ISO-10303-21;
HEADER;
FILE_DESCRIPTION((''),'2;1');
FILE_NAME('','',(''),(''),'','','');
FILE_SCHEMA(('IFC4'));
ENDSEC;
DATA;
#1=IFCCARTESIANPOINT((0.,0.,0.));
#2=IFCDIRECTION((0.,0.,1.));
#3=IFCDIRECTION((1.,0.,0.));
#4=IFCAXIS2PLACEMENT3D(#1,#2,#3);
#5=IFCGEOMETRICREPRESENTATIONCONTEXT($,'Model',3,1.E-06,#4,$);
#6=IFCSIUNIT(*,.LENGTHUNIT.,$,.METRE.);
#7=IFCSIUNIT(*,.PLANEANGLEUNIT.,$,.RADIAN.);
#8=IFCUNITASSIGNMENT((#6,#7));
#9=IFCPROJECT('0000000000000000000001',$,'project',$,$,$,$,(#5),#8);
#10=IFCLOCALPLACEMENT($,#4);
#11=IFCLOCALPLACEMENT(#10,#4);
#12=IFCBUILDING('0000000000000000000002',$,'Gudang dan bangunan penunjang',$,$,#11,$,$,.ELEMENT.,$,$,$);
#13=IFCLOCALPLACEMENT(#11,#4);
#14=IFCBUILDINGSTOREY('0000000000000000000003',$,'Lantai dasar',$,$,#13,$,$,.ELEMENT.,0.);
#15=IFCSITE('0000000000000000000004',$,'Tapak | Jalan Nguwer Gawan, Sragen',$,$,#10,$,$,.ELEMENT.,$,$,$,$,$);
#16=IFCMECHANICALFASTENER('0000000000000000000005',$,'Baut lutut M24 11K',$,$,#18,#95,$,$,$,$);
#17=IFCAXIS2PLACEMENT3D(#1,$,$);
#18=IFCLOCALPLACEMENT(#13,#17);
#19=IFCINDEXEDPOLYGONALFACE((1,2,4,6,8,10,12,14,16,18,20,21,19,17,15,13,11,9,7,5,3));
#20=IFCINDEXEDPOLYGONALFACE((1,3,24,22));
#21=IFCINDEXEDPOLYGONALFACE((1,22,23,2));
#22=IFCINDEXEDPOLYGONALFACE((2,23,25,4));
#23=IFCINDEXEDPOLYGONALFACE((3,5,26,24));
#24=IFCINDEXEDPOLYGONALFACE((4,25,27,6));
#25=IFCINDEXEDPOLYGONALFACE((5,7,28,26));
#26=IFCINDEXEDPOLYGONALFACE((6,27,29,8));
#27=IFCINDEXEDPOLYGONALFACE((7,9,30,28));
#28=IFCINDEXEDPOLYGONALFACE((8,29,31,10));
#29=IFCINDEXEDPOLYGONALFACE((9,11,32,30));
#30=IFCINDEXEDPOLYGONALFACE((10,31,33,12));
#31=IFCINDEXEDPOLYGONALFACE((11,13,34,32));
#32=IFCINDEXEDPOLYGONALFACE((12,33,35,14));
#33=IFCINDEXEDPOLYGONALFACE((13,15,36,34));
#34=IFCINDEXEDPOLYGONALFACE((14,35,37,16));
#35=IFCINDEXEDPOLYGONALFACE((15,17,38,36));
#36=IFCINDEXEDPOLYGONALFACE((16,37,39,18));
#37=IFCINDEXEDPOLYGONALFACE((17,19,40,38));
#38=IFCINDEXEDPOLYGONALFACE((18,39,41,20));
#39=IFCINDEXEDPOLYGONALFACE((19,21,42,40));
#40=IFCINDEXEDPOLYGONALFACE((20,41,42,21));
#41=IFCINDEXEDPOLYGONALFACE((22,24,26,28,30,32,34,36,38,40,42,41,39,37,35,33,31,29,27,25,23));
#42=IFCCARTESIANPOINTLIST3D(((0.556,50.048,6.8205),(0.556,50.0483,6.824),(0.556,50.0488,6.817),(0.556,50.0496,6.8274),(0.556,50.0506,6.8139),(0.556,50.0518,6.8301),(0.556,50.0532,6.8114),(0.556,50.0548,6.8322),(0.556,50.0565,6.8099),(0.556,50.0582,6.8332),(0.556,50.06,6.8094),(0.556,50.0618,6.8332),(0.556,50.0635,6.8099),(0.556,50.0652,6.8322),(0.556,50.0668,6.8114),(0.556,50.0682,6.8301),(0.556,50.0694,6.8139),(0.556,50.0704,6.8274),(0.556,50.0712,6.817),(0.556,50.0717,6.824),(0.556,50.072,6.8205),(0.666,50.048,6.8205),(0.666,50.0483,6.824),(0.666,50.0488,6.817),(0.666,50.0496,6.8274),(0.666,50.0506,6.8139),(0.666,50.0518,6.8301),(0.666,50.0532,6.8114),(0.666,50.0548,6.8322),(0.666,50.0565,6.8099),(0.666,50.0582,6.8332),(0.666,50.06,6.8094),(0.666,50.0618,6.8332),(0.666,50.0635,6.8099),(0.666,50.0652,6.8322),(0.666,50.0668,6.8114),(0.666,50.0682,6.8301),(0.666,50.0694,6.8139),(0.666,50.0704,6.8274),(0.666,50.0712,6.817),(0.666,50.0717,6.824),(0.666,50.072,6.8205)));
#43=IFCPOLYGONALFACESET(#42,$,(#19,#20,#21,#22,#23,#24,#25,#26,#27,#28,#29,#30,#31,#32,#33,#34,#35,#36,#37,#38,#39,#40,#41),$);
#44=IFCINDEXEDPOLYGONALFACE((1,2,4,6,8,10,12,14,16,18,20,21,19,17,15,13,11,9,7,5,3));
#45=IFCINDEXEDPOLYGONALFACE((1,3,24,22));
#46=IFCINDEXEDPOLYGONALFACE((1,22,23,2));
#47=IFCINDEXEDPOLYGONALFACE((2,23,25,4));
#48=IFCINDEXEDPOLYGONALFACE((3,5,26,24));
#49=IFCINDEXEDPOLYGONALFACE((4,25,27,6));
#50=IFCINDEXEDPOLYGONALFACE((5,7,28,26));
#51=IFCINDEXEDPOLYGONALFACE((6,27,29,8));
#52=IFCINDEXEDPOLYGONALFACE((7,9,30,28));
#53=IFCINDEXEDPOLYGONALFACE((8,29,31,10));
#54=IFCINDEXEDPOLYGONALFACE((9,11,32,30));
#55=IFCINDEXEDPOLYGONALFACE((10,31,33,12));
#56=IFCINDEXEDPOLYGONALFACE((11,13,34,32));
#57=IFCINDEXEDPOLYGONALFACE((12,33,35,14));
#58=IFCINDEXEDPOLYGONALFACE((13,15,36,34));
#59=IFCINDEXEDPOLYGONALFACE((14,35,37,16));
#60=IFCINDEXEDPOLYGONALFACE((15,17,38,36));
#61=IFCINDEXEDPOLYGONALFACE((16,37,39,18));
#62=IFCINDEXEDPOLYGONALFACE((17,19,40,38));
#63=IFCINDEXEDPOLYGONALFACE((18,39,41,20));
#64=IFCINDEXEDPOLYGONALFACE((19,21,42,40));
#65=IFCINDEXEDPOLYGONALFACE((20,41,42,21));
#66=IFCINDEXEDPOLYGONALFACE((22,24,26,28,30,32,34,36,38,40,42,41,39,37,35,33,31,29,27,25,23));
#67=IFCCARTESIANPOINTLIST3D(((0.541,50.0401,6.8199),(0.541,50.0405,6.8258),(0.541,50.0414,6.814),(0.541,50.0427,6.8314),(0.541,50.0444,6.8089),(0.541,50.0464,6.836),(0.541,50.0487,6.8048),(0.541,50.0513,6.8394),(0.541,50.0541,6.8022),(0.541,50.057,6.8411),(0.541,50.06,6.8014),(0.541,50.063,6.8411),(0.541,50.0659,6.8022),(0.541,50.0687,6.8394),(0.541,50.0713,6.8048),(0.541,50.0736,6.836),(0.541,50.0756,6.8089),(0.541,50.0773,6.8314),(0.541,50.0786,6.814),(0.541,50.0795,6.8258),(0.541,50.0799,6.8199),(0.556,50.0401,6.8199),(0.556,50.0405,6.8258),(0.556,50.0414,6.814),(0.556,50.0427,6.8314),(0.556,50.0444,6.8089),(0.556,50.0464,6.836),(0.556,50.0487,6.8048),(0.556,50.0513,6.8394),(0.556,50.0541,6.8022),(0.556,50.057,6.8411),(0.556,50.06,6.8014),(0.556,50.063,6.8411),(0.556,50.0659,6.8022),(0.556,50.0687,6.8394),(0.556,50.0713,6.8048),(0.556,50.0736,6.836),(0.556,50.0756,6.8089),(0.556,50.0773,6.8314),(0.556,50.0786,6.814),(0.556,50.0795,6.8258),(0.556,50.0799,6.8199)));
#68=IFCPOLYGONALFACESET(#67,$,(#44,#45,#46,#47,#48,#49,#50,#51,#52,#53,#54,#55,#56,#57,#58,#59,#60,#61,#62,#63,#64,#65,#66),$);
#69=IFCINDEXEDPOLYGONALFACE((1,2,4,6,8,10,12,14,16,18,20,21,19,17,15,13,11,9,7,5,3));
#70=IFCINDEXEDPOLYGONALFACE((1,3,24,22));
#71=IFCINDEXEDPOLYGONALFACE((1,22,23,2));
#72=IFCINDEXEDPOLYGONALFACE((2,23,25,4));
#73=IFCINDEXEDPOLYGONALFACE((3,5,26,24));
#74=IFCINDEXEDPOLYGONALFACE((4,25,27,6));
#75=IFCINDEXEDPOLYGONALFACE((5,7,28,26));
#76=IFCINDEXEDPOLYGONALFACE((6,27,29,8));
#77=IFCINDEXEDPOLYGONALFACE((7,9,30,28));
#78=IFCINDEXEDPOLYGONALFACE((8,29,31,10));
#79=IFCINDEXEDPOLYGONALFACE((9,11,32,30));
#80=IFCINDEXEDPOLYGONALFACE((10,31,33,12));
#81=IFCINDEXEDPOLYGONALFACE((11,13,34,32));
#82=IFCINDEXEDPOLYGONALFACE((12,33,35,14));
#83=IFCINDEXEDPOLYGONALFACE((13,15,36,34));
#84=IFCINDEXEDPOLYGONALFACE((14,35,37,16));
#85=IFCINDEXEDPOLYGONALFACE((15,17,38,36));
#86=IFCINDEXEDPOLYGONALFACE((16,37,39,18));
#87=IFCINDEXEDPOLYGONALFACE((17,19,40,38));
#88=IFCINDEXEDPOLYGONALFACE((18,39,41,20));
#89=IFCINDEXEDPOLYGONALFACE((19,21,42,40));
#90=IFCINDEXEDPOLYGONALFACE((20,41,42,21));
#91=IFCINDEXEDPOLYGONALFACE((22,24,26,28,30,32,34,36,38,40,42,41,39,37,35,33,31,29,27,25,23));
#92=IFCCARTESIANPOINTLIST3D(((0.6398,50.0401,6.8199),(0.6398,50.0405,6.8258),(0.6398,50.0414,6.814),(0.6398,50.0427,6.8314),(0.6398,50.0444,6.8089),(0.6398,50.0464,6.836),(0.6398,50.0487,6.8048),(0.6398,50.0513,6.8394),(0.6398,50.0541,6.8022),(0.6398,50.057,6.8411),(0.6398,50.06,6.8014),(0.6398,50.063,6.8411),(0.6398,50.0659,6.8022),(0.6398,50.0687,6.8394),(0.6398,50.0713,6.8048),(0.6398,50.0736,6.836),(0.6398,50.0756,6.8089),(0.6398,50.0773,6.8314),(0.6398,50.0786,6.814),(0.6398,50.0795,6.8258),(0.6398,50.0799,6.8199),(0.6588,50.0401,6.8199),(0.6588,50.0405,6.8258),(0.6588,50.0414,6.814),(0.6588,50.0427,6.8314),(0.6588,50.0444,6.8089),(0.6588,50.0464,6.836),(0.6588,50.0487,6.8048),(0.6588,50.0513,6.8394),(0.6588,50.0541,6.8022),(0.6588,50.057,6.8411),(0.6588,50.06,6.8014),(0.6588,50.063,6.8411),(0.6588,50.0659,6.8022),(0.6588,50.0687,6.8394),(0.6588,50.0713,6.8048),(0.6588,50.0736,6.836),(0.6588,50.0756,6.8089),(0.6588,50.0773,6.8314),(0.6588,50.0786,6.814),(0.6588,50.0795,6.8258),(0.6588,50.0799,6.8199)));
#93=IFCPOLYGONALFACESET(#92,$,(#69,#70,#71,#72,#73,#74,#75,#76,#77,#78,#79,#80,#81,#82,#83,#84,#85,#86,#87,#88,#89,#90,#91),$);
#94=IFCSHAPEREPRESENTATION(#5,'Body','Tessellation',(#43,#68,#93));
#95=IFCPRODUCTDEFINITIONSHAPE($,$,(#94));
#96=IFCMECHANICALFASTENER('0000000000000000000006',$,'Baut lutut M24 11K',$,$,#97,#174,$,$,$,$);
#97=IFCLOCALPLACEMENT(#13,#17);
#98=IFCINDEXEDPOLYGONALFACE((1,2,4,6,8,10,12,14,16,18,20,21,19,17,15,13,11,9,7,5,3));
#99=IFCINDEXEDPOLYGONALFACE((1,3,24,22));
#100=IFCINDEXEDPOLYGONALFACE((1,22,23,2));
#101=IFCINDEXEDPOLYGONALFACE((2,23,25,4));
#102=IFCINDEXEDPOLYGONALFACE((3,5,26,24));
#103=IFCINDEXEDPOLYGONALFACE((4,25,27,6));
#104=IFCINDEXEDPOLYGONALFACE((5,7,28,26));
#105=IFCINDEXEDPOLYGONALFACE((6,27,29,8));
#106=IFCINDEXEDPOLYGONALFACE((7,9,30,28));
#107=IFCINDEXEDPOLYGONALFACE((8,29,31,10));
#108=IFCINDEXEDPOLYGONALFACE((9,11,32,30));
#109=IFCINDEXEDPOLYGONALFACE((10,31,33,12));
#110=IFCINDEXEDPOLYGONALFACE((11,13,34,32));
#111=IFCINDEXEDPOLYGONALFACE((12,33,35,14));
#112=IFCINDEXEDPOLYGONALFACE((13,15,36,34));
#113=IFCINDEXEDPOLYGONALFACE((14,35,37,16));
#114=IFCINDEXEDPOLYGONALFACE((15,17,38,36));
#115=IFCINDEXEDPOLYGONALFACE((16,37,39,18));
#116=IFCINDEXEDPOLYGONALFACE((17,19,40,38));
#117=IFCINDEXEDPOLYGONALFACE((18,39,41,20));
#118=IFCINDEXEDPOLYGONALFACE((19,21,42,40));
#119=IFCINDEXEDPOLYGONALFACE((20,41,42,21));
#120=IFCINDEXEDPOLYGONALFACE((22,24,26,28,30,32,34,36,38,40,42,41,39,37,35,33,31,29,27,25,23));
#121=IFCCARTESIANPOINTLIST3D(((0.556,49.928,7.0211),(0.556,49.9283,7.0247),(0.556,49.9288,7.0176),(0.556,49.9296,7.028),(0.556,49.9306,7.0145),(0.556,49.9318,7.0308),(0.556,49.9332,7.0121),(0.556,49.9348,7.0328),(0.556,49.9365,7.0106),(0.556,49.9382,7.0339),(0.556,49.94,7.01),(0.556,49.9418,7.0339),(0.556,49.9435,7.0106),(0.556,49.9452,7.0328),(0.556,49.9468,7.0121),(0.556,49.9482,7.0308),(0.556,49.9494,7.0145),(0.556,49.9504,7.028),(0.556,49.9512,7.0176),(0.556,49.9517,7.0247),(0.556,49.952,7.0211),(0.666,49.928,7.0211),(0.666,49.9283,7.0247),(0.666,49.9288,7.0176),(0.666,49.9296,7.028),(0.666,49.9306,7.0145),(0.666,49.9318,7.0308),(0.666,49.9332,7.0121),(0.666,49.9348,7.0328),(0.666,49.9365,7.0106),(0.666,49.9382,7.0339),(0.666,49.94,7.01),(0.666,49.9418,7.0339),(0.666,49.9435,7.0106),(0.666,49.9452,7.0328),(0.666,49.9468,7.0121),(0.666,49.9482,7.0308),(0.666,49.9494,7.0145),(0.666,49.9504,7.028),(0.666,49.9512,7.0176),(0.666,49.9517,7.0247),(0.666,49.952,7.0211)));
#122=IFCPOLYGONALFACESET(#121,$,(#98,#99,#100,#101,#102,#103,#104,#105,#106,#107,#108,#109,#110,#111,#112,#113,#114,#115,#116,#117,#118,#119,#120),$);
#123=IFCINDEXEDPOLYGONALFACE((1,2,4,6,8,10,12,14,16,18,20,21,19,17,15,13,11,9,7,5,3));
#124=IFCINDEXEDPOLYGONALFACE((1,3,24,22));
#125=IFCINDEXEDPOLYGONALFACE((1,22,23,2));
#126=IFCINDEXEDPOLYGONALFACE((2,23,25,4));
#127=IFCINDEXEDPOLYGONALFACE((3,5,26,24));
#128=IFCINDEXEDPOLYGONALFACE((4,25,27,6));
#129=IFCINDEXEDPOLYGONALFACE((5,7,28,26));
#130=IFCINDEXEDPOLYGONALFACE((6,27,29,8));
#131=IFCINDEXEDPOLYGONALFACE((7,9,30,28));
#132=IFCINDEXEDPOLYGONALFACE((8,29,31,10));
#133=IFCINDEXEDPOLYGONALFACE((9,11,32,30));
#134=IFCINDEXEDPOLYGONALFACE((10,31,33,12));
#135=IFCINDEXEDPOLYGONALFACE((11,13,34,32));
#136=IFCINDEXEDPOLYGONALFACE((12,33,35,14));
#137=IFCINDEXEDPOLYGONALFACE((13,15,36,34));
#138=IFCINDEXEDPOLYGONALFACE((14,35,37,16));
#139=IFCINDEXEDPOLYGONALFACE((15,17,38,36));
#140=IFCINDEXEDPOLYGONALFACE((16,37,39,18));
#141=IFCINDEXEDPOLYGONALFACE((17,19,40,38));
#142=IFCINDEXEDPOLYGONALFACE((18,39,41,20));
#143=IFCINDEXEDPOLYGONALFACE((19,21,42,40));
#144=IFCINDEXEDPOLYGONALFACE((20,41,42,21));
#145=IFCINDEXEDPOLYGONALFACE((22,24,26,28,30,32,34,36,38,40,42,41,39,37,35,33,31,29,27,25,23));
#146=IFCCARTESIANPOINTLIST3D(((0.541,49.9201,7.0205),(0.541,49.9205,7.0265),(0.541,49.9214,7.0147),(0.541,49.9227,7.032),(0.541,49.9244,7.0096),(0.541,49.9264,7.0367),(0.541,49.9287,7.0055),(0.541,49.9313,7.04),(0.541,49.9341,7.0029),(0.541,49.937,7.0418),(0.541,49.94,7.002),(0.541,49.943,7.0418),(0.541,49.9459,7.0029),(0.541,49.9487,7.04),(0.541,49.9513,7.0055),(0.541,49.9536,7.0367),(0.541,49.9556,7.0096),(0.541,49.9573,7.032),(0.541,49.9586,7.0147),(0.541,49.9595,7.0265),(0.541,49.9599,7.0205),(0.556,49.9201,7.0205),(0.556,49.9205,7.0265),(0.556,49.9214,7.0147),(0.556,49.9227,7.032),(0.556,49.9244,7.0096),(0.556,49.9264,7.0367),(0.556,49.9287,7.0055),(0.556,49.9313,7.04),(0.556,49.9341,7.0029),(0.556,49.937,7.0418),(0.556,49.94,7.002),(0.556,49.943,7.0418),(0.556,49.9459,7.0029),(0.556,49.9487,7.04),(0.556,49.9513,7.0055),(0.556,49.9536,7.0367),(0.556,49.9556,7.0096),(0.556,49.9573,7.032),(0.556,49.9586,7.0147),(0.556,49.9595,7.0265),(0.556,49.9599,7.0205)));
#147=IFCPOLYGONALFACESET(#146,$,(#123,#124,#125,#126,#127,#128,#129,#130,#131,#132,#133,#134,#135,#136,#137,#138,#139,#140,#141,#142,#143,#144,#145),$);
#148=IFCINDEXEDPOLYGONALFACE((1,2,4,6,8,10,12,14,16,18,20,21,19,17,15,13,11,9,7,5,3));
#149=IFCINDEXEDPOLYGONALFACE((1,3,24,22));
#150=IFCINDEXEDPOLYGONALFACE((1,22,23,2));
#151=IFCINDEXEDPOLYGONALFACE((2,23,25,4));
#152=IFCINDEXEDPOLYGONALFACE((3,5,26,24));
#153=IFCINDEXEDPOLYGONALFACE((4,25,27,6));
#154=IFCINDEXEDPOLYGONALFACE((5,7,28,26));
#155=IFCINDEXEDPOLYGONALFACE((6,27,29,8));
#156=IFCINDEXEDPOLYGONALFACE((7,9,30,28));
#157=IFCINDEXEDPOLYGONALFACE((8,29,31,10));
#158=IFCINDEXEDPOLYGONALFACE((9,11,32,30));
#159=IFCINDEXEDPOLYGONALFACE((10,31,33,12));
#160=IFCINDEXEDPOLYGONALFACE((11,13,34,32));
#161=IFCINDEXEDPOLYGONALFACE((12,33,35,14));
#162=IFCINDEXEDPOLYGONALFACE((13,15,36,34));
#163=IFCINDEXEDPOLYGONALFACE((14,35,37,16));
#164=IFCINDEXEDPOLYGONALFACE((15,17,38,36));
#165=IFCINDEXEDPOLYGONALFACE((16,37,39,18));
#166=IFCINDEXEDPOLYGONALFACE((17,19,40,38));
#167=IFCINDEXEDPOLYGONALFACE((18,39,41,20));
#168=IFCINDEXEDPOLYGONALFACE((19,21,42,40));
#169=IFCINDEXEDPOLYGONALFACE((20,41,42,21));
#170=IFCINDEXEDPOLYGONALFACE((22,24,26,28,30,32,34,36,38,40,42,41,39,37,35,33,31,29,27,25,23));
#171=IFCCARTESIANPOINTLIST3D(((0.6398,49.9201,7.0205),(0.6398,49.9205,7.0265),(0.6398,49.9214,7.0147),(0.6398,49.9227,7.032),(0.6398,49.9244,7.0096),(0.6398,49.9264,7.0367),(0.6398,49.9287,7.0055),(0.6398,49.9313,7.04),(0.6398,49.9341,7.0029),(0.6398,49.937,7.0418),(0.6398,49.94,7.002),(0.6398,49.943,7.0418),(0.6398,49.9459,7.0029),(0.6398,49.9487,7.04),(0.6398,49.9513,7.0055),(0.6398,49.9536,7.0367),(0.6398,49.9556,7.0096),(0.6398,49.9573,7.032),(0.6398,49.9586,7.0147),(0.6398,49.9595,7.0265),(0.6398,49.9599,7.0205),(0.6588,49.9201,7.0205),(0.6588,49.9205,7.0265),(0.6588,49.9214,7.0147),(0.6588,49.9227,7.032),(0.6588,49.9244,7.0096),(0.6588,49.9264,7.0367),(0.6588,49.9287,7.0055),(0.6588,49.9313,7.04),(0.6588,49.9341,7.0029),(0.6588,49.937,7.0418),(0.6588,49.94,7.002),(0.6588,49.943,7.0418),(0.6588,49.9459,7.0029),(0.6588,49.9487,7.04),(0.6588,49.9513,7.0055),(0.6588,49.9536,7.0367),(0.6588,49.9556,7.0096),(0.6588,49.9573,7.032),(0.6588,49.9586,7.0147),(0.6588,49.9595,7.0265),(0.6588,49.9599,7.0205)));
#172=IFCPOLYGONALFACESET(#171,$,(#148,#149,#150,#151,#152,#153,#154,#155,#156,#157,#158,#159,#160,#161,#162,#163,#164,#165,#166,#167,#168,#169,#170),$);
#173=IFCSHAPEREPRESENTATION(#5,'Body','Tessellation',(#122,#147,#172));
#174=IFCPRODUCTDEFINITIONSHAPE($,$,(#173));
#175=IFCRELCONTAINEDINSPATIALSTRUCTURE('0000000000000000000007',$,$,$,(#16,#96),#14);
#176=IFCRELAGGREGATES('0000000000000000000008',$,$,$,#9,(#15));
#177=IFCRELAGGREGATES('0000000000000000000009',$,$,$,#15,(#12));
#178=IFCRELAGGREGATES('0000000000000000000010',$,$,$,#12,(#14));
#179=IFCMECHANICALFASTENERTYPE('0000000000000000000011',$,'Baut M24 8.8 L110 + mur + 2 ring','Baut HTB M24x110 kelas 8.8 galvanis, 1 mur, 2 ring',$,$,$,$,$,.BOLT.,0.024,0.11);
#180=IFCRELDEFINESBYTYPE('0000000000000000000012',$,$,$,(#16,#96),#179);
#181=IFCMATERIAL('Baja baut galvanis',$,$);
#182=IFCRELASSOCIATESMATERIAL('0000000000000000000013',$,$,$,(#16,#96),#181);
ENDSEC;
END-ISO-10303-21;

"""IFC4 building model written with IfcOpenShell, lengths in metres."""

from ifc_helpers import new_model, si_unit, frame, origin_with_axes, place, context, project, spatial, circle, extrude, source, transform, mapped, material, type_object, type_shapes, element, save


model = new_model("IFC4")

# Units and contexts
model_context = context("Model", 3, precision=1e-06, world=origin_with_axes())
ifc_project = project(units=[si_unit("LENGTHUNIT", "METRE"), si_unit("PLANEANGLEUNIT", "RADIAN")], contexts=[model_context])

# Site, building, storey
site_placement = place(None, origin_with_axes())
site = spatial("IfcSite", under=ifc_project, at=site_placement, Name="Tapak | Jalan Nguwer Gawan, Sragen", CompositionType="ELEMENT")
building_placement = place(site_placement, origin_with_axes())
building = spatial("IfcBuilding", under=site, at=building_placement, Name="Gudang dan bangunan penunjang", CompositionType="ELEMENT")
storey_placement = place(building_placement, origin_with_axes())
storey = spatial("IfcBuildingStorey", under=building, at=storey_placement, Name="Lantai dasar", CompositionType="ELEMENT", Elevation=0.0)

# Shared definitions
placement = place(None, origin_with_axes())

# Mechanical fasteners
ifc_material_1 = material(Name="Baja baut galvanis")
mechanical_fastener_type_1 = type_object("IfcMechanicalFastenerType", Name="Baut M24 8.8 L110 + mur + 2 ring", Description="Baut HTB M24x110 kelas 8.8 galvanis, 1 mur, 2 ring", NominalDiameter=0.024, NominalLength=0.11, PredefinedType="BOLT")
shared_shape_1 = source(origin_with_axes(), model_context, "Body", "SweptSolid", [
    extrude(circle(Radius=0.012), origin_with_axes(), (0.0, 0.0, 1.0), 0.11),
    extrude(circle(Radius=0.02), frame((0.0, 0.0, -0.015), z_axis=(0.0, 0.0, 1.0), x_axis=(1.0, 0.0, 0.0)), (0.0, 0.0, 1.0), 0.015),
    extrude(circle(Radius=0.02), frame((0.0, 0.0, 0.0838), z_axis=(0.0, 0.0, 1.0), x_axis=(1.0, 0.0, 0.0)), (0.0, 0.0, 1.0), 0.019),
])
type_shapes(mechanical_fastener_type_1, [shared_shape_1])
element("IfcMechanicalFastener", 1, at=placement, inside=storey, type_object=mechanical_fastener_type_1, material=ifc_material_1, Name="Baut lutut M24 11K", context=model_context, shape_type="MappedRepresentation", body=[
    mapped(shared_shape_1, transform((0.556, 50.06, 6.8213), x_axis=(0.0, 0.0, -1.0), y_axis=(0.0, 1.0, 0.0), z_axis=(1.0, 0.0, 0.0), scale=1.0)),
])
element("IfcMechanicalFastener", 2, at=placement, inside=storey, type_object=mechanical_fastener_type_1, material=ifc_material_1, Name="Baut lutut M24 11K", context=model_context, shape_type="MappedRepresentation", body=[
    mapped(shared_shape_1, transform((0.556, 49.94, 7.022), x_axis=(0.0, 0.0, -1.0), y_axis=(0.0, 1.0, 0.0), z_axis=(1.0, 0.0, 0.0), scale=1.0)),
])

save(model, "model.ifc")
